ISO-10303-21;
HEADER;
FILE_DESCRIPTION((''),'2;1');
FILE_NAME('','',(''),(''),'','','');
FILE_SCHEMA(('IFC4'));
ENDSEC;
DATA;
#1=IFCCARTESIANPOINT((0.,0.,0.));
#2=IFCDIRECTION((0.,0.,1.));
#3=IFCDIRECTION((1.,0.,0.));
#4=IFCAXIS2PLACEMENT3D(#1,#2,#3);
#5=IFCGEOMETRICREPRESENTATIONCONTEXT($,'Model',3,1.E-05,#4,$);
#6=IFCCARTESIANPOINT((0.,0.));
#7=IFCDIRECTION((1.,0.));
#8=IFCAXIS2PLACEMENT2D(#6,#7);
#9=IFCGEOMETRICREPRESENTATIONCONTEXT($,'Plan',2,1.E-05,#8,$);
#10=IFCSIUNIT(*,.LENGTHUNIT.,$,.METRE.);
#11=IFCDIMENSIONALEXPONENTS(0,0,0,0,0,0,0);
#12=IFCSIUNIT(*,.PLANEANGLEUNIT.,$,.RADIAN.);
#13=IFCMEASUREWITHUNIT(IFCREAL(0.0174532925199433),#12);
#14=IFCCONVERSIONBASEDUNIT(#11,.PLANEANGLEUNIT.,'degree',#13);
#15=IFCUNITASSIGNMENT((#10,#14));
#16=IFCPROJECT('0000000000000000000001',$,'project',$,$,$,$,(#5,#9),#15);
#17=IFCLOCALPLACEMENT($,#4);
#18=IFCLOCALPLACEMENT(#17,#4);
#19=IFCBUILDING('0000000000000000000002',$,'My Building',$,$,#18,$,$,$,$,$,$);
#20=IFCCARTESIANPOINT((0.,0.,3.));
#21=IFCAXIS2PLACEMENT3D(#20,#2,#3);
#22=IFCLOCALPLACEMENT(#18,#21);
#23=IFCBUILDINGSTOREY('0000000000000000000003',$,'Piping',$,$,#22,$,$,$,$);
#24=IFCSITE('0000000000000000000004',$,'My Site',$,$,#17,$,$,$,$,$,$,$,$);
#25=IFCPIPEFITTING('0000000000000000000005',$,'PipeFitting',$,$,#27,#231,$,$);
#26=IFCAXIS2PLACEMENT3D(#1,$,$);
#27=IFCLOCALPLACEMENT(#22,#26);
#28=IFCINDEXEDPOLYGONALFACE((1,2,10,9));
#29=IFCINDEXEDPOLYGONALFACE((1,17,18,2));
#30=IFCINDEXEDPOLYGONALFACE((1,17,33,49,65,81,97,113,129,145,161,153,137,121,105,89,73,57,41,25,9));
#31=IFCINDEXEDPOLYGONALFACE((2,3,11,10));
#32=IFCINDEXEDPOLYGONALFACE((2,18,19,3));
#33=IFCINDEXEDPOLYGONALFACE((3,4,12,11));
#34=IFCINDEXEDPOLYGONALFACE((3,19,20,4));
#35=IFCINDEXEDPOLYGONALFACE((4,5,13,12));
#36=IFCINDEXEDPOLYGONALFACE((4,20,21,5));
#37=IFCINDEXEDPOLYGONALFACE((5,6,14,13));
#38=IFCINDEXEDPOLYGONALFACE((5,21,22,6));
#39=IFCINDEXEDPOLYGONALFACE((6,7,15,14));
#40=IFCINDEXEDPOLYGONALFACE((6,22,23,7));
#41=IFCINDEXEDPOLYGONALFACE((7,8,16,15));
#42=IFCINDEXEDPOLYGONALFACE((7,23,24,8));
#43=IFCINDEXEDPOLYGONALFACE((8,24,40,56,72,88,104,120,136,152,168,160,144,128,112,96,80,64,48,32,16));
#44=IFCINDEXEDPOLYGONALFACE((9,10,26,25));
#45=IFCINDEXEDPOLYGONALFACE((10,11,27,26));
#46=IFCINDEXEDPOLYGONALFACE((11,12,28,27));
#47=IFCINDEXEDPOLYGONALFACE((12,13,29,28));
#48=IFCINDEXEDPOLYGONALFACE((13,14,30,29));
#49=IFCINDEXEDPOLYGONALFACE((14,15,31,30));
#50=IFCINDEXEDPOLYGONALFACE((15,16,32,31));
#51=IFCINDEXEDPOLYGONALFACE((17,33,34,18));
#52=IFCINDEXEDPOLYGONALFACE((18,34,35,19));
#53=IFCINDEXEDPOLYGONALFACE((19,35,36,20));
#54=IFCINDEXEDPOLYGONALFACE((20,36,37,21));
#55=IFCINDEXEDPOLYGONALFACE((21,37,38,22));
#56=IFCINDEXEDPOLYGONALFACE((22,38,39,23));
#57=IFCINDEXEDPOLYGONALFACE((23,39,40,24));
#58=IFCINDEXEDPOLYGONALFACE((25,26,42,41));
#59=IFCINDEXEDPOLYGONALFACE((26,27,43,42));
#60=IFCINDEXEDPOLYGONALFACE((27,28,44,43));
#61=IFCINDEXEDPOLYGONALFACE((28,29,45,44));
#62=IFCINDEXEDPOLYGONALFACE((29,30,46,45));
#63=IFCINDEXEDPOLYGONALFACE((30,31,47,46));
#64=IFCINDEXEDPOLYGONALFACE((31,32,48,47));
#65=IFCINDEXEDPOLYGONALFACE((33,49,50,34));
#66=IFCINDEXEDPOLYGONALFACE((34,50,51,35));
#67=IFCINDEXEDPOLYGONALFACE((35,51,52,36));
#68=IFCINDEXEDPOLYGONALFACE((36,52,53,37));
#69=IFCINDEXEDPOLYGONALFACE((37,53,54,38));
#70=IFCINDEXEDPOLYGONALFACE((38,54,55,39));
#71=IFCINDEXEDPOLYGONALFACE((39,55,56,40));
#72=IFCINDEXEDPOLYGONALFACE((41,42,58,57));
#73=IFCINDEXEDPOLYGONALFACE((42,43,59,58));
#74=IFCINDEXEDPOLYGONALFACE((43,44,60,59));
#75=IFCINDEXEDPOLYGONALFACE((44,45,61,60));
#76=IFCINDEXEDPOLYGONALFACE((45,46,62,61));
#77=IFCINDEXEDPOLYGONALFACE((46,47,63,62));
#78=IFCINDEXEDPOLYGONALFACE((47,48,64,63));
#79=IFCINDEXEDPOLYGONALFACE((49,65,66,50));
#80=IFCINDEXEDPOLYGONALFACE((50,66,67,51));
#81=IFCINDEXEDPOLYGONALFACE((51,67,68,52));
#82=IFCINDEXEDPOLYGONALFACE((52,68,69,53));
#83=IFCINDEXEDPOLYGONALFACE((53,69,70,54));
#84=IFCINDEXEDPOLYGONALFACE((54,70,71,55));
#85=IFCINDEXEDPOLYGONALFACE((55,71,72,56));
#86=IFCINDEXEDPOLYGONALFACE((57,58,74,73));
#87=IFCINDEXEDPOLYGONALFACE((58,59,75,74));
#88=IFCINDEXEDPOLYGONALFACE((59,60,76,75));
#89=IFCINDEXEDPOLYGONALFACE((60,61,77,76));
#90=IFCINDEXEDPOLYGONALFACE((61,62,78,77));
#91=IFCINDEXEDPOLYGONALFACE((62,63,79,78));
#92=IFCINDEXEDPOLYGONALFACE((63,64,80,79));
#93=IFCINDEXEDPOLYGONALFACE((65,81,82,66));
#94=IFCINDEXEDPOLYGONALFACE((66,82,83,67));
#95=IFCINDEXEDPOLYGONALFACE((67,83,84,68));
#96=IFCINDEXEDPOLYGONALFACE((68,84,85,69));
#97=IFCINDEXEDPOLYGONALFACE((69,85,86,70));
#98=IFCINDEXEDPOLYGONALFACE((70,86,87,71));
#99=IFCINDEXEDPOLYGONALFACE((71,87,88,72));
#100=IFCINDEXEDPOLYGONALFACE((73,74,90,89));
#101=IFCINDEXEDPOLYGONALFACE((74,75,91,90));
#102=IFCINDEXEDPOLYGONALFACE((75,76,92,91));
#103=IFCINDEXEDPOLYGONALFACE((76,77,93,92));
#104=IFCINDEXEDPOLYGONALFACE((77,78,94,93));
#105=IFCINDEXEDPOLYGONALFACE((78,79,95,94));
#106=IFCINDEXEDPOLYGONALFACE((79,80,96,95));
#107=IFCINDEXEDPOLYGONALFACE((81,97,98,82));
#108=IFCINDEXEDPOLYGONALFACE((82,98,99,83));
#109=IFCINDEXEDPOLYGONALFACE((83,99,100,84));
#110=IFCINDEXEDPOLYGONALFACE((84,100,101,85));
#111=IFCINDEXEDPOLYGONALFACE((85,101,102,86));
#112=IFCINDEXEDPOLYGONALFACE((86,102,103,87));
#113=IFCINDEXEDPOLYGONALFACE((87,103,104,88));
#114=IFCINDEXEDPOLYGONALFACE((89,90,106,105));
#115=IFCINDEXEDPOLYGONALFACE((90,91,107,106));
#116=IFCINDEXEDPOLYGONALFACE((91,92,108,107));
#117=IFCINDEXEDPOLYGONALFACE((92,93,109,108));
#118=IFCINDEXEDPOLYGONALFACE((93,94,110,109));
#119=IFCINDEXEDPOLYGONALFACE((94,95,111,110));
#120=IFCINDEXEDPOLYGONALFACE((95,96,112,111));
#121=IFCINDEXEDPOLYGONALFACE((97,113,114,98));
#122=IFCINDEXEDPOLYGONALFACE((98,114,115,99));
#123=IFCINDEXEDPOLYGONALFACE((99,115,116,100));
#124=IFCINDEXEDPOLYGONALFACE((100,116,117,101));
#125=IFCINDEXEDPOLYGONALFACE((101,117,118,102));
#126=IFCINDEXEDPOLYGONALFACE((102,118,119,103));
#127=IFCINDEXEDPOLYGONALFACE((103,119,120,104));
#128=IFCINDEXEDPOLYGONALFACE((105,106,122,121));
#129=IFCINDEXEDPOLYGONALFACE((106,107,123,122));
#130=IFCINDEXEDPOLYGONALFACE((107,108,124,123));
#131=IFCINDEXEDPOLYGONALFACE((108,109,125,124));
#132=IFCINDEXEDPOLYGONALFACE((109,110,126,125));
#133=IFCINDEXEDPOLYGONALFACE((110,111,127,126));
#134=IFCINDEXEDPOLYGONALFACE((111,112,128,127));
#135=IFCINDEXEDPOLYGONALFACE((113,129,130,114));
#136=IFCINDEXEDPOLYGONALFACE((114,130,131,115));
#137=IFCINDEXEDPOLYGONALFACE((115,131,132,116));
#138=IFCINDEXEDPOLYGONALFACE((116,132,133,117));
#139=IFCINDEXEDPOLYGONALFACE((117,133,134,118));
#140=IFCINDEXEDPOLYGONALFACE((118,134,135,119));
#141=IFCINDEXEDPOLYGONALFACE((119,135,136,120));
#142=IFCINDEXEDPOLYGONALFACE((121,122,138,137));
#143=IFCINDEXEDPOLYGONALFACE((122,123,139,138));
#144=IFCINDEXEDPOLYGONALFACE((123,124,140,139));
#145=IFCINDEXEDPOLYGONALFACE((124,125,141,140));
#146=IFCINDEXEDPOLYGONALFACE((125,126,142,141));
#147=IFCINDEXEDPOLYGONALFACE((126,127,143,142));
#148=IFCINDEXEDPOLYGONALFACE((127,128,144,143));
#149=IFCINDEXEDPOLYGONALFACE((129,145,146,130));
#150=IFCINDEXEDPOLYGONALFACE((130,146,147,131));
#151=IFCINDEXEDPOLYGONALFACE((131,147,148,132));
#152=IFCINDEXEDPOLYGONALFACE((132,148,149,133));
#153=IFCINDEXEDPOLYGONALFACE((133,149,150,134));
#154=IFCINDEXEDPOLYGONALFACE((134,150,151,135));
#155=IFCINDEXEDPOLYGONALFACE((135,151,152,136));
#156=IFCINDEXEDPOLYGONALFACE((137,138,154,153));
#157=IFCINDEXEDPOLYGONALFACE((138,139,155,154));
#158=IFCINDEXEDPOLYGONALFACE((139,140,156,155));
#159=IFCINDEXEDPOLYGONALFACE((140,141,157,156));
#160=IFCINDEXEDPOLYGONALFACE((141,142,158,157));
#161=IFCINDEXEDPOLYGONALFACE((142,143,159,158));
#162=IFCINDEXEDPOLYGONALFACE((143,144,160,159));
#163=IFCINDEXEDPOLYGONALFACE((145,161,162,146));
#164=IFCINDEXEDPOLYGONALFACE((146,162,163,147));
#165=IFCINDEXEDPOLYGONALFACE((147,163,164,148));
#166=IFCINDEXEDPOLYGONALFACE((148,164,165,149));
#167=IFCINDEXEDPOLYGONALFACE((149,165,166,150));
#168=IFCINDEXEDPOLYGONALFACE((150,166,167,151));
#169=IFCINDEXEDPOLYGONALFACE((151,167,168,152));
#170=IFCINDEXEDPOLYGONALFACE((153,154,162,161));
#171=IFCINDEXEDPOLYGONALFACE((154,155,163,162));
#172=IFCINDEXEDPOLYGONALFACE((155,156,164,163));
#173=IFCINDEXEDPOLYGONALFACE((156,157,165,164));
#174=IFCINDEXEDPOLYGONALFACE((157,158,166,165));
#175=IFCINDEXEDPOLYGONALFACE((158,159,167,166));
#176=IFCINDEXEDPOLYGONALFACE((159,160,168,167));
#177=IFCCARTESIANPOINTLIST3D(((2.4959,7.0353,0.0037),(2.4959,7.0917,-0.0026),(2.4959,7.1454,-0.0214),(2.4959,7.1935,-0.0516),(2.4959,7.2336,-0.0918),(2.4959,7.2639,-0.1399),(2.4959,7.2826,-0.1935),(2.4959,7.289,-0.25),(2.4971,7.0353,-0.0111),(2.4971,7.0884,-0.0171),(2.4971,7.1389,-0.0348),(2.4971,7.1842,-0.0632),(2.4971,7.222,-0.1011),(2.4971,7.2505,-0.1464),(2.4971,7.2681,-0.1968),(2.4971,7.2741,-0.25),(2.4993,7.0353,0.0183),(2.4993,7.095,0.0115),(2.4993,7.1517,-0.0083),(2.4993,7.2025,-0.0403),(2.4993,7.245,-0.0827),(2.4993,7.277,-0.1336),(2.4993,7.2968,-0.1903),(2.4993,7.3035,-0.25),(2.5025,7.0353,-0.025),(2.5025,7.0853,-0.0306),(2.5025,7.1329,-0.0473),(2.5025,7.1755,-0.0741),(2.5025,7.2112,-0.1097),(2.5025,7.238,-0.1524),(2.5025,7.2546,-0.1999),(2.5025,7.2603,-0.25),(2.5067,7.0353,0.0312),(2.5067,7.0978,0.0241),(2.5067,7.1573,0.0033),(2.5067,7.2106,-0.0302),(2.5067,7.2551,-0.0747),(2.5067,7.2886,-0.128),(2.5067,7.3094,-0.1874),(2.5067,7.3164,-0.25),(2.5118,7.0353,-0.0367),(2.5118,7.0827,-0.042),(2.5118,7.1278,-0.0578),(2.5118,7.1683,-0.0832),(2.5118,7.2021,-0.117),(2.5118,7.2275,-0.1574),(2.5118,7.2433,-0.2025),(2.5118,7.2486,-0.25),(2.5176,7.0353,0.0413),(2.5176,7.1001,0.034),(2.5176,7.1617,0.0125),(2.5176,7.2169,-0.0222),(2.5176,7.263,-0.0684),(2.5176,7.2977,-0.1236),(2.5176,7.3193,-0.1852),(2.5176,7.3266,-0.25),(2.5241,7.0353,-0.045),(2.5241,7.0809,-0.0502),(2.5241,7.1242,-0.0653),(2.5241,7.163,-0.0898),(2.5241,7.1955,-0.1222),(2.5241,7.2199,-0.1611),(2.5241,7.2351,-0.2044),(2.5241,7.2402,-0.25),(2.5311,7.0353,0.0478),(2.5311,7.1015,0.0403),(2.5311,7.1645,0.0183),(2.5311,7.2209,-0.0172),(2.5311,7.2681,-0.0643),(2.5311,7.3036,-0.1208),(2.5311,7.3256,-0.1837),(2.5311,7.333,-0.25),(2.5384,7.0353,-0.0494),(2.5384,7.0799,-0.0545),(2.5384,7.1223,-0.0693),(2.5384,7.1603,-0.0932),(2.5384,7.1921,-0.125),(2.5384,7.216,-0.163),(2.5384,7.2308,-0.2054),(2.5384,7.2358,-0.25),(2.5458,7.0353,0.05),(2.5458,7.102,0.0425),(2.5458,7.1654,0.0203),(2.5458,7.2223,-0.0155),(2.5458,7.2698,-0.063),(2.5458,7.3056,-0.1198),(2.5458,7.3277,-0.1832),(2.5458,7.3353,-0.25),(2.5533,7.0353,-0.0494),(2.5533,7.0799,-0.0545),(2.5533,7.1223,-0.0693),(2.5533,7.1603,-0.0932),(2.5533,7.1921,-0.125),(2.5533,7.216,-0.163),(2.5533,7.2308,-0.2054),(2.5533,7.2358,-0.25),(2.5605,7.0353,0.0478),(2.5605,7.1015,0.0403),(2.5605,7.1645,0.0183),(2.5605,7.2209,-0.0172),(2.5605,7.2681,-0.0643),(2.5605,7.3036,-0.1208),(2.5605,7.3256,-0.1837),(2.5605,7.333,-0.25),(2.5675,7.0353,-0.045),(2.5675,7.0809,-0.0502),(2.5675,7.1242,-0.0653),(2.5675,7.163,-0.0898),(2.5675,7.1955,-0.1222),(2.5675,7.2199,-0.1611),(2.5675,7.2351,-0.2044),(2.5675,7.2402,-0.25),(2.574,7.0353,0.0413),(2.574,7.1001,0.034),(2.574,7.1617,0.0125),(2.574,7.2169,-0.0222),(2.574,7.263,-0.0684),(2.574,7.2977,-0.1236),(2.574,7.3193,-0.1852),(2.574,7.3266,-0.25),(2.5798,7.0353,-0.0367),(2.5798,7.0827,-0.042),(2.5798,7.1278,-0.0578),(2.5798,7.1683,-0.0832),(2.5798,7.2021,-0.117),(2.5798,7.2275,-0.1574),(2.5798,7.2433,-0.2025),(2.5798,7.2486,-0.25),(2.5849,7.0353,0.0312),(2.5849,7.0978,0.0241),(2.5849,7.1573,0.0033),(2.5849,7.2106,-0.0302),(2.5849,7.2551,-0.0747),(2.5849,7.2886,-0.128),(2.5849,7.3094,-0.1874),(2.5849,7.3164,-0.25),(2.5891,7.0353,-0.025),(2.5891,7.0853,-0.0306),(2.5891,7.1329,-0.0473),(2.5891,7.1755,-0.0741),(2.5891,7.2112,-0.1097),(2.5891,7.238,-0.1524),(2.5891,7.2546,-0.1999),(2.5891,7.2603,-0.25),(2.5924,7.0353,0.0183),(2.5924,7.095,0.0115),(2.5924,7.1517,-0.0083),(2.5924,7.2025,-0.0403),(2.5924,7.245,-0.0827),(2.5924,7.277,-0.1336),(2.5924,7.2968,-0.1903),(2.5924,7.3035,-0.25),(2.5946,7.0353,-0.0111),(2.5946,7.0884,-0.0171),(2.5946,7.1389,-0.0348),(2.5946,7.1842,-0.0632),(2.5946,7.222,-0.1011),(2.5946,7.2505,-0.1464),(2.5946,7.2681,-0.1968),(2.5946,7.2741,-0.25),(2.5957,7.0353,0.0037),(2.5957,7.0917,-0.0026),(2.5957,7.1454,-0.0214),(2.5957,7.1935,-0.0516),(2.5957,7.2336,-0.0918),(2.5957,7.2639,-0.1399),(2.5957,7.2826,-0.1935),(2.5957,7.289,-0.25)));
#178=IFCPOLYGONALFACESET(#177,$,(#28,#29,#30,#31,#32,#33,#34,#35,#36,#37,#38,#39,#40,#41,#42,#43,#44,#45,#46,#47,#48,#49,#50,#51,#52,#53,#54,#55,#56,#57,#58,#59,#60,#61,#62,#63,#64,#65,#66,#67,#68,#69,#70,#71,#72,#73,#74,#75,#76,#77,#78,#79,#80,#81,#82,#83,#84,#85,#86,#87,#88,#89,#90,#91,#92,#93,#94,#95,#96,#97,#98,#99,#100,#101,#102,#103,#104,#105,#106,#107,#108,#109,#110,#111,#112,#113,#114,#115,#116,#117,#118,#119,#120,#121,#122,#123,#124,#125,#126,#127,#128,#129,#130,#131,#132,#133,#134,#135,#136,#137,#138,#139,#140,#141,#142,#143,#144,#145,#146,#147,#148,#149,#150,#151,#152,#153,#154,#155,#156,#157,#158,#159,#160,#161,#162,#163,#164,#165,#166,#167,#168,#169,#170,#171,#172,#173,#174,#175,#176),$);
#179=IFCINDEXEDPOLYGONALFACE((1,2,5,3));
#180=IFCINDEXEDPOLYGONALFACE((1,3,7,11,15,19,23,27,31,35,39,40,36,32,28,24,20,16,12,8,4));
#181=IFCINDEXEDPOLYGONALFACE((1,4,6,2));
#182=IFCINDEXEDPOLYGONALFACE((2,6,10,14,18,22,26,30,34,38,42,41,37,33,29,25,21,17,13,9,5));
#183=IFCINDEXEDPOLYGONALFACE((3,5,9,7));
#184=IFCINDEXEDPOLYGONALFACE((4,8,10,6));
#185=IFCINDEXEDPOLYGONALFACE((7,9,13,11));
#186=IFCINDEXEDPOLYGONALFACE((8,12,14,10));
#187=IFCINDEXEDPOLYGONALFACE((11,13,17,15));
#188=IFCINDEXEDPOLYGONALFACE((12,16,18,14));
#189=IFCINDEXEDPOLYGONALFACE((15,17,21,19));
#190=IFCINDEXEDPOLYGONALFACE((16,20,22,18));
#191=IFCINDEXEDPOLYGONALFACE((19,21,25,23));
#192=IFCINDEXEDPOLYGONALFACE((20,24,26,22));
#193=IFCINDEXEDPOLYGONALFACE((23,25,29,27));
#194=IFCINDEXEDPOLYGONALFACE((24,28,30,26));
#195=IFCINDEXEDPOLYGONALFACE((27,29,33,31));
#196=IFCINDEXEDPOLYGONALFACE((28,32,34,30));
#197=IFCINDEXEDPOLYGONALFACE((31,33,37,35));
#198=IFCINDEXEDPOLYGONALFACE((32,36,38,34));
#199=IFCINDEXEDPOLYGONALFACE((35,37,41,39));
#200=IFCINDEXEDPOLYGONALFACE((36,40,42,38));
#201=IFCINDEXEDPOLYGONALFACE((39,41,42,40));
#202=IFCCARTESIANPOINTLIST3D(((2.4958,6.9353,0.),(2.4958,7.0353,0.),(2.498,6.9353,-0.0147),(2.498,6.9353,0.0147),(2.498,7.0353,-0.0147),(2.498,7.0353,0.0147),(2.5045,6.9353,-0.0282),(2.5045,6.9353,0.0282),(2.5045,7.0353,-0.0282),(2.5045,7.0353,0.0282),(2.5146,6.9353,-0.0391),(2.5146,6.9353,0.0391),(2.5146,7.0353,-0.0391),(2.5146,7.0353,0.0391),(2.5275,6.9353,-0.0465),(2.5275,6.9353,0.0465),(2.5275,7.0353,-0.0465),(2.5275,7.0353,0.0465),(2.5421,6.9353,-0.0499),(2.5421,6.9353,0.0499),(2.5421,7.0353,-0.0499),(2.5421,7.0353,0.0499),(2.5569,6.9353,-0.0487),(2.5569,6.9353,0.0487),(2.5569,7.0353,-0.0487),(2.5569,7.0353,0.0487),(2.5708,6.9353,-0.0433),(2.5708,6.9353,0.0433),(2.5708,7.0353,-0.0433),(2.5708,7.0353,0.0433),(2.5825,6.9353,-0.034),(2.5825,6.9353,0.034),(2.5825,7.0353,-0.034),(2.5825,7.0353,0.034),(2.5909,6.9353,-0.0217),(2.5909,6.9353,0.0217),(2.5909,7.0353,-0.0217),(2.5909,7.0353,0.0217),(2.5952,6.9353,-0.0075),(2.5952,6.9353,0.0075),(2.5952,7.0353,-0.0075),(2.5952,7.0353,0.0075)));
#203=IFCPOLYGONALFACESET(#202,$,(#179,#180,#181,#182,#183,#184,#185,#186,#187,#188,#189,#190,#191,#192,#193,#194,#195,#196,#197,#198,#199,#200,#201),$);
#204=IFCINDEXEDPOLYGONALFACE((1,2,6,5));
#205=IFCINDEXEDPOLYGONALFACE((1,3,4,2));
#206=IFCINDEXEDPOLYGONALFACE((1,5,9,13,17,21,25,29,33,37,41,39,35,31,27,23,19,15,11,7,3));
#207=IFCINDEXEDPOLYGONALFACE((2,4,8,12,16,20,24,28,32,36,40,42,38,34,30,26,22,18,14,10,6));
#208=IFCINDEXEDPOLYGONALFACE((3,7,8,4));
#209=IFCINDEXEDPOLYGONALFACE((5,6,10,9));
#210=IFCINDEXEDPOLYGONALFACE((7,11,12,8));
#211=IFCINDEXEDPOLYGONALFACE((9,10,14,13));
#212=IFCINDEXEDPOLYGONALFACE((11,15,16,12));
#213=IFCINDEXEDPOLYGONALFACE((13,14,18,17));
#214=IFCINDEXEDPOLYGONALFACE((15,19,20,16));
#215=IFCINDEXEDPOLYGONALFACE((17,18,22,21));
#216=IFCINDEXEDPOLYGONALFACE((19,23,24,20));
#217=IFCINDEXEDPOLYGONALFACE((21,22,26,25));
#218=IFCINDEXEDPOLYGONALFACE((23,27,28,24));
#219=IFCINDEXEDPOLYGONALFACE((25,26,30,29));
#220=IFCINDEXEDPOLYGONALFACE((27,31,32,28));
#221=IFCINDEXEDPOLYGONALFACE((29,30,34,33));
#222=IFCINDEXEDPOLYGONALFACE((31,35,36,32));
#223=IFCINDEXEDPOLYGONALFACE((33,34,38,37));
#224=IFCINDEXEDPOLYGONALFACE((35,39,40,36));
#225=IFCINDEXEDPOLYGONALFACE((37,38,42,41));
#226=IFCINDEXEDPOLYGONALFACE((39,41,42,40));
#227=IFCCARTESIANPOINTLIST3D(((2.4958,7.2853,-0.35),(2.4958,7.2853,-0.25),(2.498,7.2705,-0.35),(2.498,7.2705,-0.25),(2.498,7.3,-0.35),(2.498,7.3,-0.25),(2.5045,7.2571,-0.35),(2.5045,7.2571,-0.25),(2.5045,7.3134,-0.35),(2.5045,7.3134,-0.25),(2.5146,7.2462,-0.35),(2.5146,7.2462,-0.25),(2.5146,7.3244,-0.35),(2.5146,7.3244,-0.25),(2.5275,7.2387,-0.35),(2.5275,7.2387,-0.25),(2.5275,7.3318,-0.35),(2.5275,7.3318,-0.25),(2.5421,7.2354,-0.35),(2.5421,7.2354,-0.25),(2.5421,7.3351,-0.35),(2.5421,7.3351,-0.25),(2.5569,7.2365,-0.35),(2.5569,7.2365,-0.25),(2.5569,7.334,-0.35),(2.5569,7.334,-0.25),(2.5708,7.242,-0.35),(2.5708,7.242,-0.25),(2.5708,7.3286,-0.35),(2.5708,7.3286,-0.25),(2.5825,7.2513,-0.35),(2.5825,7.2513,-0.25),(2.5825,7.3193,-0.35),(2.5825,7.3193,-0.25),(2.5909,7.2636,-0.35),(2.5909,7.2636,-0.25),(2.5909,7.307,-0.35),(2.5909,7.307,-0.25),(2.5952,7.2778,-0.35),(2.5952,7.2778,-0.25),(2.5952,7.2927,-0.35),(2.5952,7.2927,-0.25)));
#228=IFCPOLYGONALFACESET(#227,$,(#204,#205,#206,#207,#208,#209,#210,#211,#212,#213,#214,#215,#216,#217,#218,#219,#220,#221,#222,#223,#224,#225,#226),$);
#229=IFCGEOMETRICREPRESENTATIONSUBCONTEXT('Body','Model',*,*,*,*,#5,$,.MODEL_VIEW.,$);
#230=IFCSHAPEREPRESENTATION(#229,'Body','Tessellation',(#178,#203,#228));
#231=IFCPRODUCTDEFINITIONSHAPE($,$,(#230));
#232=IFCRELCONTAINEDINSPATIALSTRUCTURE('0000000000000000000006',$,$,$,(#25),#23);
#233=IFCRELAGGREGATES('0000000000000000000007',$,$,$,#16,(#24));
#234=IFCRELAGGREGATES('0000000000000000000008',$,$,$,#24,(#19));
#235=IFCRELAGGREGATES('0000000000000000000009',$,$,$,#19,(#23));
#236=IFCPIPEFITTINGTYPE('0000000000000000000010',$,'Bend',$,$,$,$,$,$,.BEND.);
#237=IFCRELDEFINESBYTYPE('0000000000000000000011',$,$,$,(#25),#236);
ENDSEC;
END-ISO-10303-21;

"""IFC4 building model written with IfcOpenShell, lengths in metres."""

from ifc_helpers import new_model, entity, si_unit, converted_unit, frame, origin_with_axes, origin_2d_with_axis, place, context, subcontext, project, spatial, circle, extrude, source, transform, mapped, type_object, type_shapes, element, save


model = new_model("IFC4")

# Units and contexts
model_context = context("Model", 3, precision=1e-05, world=origin_with_axes())
plan_context = context("Plan", 2, precision=1e-05, world=origin_2d_with_axis())
body_context = subcontext(model_context, "Body", "Model", "MODEL_VIEW")
ifc_project = project(units=[si_unit("LENGTHUNIT", "METRE"), converted_unit("PLANEANGLEUNIT", "degree", entity("IfcReal", 0.0174532925199433), si_unit("PLANEANGLEUNIT", "RADIAN"), dimensions=[0, 0, 0, 0, 0, 0, 0])], contexts=[model_context, plan_context])

# Site, building, storey
site_placement = place(None, origin_with_axes())
site = spatial("IfcSite", under=ifc_project, at=site_placement, Name="My Site")
building_placement = place(site_placement, origin_with_axes())
building = spatial("IfcBuilding", under=site, at=building_placement, Name="My Building")
storey_placement = place(building_placement, frame((0.0, 0.0, 3.0), z_axis=(0.0, 0.0, 1.0), x_axis=(1.0, 0.0, 0.0)))
storey = spatial("IfcBuildingStorey", under=building, at=storey_placement, Name="Piping")

# Pipe fitting
pipe_fitting_type_1 = type_object("IfcPipeFittingType", Name="Bend", PredefinedType="BEND")
shared_shape = source(origin_with_axes(), body_context, "Body", "SolidModel", [
    entity("IfcSweptDiskSolid", entity("IfcIndexedPolyCurve", entity("IfcCartesianPointList3D", [[0.0, 0.0, -0.1], [0.0, 0.0732, -0.2768], [0.0, 0.25, -0.35]]), [entity("IfcArcIndex", [1, 2, 3])]), 0.05),
    extrude(circle(Radius=0.05), origin_with_axes(), (0.0, 0.0, -1.0), 0.1),
    extrude(circle(Radius=0.05), frame((0.0, 0.25, -0.35), z_axis=(0.0, 1.0, 0.0), x_axis=(1.0, 0.0, 0.0)), (0.0, 0.0, 1.0), 0.1),
])
type_shapes(pipe_fitting_type_1, [shared_shape])
for number, where, z_axis, x_axis, name in (
    (1, (2.5458, 6.9353, 0.0), (0.0, -1.0, 0.0), (-1.0, 0.0, 0.0), "PipeFitting"),
):
    element("IfcPipeFitting", number, at=place(storey_placement, frame(where, z_axis=z_axis, x_axis=x_axis)), inside=storey, type_object=pipe_fitting_type_1, Name=name, context=body_context, shape_type="MappedRepresentation", body=[
        mapped(shared_shape, transform((0.0, 0.0, 0.0), x_axis=(1.0, 0.0, 0.0), y_axis=(0.0, 1.0, 0.0), z_axis=(0.0, 0.0, 1.0), scale=1.0)),
    ])

save(model, "model.ifc")
